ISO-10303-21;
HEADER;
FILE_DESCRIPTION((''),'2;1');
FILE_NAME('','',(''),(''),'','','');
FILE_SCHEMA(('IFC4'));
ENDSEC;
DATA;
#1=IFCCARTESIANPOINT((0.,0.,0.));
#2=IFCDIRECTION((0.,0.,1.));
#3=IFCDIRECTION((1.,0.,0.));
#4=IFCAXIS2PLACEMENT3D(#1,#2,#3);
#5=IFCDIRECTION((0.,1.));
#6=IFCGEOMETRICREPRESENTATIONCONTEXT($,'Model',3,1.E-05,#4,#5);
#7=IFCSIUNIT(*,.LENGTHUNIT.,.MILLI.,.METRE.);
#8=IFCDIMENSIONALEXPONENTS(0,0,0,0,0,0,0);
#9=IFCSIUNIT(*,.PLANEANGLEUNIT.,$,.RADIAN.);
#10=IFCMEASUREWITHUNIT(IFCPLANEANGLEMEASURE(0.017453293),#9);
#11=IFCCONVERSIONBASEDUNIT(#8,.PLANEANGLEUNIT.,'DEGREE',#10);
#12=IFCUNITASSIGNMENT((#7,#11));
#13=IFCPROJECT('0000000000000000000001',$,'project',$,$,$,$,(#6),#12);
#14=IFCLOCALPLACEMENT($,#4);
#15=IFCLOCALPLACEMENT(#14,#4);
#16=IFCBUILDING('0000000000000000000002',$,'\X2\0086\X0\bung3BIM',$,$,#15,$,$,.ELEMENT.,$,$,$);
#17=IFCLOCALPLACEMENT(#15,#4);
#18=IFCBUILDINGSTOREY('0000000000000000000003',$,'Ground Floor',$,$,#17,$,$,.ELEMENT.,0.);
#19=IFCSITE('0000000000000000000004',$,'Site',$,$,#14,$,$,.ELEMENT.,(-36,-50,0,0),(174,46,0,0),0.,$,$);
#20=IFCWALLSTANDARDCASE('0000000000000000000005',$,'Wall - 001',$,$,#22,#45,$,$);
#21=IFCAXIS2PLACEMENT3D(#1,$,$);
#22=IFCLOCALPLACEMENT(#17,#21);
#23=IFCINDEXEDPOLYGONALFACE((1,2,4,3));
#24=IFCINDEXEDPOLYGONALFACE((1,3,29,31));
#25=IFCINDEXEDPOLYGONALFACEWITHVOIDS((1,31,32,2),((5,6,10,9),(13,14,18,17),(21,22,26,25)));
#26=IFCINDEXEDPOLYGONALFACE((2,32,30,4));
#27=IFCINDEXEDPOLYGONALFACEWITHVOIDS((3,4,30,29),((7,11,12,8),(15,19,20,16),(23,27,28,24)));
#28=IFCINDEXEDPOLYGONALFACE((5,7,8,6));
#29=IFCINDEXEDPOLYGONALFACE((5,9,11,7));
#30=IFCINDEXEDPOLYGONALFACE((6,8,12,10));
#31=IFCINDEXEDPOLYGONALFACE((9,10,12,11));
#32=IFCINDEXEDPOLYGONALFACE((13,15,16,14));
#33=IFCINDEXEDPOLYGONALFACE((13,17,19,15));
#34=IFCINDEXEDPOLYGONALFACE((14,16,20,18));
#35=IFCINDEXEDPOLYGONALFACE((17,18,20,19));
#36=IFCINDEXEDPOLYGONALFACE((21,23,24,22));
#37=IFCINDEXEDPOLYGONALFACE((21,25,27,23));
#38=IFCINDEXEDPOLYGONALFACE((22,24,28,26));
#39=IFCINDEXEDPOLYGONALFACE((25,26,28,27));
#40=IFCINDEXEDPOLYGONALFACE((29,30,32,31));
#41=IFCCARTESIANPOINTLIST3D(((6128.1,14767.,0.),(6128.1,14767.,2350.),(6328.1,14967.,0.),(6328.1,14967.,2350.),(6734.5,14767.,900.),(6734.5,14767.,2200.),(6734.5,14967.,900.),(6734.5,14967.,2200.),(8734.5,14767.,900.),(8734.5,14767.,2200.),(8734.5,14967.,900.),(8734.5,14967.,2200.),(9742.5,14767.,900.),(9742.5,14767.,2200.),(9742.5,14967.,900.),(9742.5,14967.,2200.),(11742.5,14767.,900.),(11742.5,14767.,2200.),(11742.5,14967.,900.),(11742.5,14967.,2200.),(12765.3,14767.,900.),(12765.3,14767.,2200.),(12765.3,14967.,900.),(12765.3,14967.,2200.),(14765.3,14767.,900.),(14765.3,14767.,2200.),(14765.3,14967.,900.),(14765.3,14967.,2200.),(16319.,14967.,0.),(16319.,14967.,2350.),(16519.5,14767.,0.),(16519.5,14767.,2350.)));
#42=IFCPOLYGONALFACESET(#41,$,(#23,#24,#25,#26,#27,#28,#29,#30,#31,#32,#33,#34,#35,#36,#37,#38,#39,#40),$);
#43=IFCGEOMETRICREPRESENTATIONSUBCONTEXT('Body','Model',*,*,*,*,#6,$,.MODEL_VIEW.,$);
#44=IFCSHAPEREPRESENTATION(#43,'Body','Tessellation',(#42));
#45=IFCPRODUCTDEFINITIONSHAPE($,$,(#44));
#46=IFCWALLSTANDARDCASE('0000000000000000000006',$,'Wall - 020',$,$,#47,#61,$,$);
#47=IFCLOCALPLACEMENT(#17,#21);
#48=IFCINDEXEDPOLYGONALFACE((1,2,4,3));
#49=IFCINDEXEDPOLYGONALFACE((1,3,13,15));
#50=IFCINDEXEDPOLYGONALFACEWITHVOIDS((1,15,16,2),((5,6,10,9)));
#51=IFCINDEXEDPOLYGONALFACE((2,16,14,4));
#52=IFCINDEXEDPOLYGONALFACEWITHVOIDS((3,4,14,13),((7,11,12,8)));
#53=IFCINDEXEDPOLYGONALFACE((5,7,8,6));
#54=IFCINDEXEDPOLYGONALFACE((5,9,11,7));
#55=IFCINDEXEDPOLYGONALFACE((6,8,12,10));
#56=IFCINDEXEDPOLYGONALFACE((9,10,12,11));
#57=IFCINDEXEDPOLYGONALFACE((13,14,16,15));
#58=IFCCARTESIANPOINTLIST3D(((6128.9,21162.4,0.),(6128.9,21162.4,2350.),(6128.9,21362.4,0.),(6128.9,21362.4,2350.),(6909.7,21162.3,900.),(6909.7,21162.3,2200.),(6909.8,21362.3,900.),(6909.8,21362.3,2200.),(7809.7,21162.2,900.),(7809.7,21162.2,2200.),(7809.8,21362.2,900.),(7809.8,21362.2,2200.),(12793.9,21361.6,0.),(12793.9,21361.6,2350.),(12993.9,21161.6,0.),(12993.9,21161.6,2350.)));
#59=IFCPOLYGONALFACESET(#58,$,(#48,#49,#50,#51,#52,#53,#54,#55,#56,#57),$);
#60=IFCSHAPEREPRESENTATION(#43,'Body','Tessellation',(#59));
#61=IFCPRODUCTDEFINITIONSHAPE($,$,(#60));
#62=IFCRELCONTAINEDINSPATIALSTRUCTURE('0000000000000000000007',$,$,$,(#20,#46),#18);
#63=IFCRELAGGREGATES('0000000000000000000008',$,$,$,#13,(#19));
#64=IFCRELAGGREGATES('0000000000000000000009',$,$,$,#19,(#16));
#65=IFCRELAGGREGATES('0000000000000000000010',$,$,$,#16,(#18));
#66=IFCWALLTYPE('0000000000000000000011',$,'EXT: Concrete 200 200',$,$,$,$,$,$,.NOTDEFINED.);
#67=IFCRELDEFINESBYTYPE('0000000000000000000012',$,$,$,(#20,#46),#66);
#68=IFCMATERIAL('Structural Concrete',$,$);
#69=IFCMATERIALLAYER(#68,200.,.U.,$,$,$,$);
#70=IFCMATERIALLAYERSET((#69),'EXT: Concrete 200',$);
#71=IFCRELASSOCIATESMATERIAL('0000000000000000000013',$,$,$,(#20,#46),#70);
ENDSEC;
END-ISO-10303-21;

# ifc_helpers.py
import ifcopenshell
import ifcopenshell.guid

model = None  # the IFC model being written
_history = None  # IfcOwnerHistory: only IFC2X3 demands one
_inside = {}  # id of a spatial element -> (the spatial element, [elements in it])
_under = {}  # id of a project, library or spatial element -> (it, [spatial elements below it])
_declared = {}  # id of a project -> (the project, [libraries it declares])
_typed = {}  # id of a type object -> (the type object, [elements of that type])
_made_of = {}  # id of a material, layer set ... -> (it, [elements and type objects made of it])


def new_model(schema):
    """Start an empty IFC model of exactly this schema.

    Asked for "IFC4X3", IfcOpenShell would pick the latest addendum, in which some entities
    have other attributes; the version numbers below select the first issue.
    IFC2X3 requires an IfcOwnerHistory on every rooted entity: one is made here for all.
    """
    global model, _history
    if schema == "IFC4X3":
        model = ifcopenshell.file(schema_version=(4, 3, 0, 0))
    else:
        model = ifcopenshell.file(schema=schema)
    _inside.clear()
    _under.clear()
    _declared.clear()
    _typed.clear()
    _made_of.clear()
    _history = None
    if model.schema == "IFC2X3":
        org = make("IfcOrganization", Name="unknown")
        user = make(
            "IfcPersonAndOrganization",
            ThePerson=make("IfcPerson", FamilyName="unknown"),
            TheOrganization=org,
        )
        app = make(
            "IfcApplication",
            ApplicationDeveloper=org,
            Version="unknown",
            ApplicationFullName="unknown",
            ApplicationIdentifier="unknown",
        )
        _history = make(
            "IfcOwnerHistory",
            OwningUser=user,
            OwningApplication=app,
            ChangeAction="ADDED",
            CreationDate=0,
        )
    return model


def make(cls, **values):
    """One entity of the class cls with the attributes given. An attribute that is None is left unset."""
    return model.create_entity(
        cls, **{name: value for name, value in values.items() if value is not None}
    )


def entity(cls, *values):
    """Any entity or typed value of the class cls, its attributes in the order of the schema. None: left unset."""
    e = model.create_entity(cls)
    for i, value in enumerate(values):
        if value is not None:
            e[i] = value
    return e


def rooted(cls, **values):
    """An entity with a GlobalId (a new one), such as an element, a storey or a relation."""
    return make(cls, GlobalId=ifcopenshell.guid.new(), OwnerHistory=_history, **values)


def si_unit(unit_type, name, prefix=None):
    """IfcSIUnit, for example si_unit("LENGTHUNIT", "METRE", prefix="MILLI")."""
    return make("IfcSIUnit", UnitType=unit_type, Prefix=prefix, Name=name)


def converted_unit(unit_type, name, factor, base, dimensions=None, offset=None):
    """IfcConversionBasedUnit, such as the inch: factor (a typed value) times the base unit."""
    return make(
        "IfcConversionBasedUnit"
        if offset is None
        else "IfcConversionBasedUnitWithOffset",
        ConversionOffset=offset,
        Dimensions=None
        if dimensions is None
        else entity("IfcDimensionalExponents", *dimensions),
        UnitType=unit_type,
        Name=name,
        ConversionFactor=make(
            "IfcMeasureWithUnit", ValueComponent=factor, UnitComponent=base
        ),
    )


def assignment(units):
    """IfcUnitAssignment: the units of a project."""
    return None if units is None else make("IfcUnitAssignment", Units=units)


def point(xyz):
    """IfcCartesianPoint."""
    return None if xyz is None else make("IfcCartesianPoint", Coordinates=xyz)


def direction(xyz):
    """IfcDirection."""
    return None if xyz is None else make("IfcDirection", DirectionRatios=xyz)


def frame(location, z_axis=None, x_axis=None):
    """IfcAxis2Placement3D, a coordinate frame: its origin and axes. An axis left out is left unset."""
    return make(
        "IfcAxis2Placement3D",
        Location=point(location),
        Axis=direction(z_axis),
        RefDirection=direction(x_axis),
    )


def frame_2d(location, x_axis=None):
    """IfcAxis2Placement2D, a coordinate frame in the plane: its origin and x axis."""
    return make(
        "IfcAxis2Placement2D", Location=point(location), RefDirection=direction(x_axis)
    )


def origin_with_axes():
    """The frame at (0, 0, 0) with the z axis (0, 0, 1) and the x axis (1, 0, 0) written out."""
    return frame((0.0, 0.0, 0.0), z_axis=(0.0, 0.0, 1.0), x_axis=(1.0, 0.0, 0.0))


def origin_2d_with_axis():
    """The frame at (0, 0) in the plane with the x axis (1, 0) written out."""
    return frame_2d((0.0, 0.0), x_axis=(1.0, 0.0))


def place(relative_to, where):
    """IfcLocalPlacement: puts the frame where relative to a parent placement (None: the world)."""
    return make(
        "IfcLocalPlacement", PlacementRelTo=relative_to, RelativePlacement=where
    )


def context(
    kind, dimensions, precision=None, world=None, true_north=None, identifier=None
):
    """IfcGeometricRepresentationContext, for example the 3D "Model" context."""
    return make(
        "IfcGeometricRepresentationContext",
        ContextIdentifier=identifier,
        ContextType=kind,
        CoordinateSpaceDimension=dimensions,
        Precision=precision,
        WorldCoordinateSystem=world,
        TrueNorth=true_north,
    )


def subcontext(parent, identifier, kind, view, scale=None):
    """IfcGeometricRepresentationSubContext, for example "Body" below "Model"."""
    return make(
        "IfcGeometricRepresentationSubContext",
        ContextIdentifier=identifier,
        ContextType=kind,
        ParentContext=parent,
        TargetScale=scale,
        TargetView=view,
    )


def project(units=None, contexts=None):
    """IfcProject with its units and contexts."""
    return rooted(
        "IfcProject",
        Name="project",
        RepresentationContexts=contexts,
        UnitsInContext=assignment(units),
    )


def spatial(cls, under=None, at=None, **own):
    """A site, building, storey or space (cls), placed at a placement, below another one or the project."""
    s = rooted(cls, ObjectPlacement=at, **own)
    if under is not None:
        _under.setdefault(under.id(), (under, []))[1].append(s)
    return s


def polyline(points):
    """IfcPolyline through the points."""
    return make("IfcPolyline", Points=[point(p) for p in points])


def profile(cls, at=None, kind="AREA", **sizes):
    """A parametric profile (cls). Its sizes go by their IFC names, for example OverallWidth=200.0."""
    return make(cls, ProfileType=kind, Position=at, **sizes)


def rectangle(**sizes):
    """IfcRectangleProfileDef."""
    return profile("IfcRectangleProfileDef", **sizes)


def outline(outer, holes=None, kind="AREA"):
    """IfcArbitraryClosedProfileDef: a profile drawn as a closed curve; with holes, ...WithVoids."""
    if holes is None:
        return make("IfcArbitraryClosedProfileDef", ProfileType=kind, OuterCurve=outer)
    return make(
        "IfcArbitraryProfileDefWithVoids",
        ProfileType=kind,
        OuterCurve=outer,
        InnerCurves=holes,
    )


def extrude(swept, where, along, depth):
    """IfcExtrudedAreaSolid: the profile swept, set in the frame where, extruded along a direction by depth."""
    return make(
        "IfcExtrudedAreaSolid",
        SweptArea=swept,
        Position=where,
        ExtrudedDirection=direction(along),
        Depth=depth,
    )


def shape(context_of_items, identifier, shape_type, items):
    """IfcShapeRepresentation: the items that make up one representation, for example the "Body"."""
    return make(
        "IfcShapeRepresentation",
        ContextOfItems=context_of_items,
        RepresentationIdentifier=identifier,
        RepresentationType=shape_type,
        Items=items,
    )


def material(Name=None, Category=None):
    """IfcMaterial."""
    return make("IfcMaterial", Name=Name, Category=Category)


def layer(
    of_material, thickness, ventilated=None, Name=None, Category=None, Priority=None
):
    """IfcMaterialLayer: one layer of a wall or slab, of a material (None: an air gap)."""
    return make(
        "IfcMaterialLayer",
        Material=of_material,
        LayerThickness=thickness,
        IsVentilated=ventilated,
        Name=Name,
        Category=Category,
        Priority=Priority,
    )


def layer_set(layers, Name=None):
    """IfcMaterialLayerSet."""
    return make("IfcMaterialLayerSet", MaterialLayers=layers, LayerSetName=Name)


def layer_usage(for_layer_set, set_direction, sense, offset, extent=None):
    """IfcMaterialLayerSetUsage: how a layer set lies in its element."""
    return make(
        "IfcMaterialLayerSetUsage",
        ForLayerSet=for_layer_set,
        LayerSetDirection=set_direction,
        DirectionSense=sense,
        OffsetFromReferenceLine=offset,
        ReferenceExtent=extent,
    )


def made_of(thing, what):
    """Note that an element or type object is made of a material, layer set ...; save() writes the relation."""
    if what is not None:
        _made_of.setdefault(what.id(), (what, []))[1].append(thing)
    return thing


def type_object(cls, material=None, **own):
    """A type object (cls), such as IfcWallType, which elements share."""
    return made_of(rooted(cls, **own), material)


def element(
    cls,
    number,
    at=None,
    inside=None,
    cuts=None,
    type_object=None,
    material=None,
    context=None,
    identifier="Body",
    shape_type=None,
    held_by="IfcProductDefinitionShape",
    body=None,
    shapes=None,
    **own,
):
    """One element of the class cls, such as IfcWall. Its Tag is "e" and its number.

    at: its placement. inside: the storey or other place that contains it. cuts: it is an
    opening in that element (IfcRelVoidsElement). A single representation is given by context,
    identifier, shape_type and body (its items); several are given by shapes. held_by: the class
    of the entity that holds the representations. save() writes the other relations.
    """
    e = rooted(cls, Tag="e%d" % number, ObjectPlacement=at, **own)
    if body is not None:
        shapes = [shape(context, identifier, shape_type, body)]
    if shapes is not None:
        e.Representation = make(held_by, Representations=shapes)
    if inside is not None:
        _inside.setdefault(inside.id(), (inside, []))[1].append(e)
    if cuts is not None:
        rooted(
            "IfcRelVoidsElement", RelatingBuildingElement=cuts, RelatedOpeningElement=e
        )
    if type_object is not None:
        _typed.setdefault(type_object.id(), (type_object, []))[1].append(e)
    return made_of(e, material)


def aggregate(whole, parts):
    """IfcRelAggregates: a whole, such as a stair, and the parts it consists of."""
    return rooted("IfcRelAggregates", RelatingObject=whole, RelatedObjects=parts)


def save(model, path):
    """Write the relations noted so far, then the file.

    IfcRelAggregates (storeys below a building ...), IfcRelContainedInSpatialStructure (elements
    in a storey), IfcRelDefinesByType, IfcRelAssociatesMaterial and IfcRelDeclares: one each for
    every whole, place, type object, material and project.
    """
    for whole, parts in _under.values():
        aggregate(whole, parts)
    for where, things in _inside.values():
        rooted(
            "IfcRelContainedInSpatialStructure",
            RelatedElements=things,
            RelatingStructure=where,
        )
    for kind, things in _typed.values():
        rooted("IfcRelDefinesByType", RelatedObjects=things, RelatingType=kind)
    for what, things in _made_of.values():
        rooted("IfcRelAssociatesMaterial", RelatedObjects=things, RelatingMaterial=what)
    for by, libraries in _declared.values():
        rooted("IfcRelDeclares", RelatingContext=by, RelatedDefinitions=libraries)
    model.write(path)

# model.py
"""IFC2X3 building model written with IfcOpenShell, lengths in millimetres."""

from ifc_helpers import new_model, entity, si_unit, converted_unit, direction, frame, origin_with_axes, origin_2d_with_axis, place, context, subcontext, project, spatial, polyline, rectangle, outline, extrude, material, layer, layer_set, layer_usage, type_object, element, save


model = new_model("IFC2X3")

# Units and contexts
model_context = context("Model", 3, precision=1e-05, world=origin_with_axes(), true_north=direction((0.0, 1.0)))
body_context = subcontext(model_context, "Body", "Model", "MODEL_VIEW")
ifc_project = project(units=[si_unit("LENGTHUNIT", "METRE", prefix="MILLI"), converted_unit("PLANEANGLEUNIT", "DEGREE", entity("IfcPlaneAngleMeasure", 0.017453293), si_unit("PLANEANGLEUNIT", "RADIAN"), dimensions=[0, 0, 0, 0, 0, 0, 0])], contexts=[model_context])

# Site, building, storey
site_placement = place(None, origin_with_axes())
site = spatial("IfcSite", under=ifc_project, at=site_placement, Name="Site", CompositionType="ELEMENT", RefLatitude=(-36, -50, 0, 0), RefLongitude=(174, 46, 0, 0), RefElevation=0.0)
building_placement = place(site_placement, origin_with_axes())
building = spatial("IfcBuilding", under=site, at=building_placement, Name="\u0086bung3BIM", CompositionType="ELEMENT")
storey_placement = place(building_placement, origin_with_axes())
storey = spatial("IfcBuildingStorey", under=building, at=storey_placement, Name="Ground Floor", CompositionType="ELEMENT", Elevation=0.0)

# Shared definitions
ifc_material_1 = material(Name="Structural Concrete")
ifc_layer_1 = layer(ifc_material_1, 200.0, ventilated="UNKNOWN")
ifc_layer_set_1 = layer_set([ifc_layer_1], Name="EXT: Concrete 200")
wall_type_1 = type_object("IfcWallType", Name="EXT: Concrete 200 200", PredefinedType="NOTDEFINED")

# Wall, openings
ifc_layer_usage_1 = layer_usage(ifc_layer_set_1, "AXIS2", "POSITIVE", 0.0)
wall_1_placement = place(storey_placement, frame((16319.0, 14967.0, 0.0), z_axis=(0.0, 0.0, 1.0), x_axis=(-1.0, 0.0, 0.0)))
wall_1 = element("IfcWallStandardCase", 1, at=wall_1_placement, inside=storey, type_object=wall_type_1, material=ifc_layer_usage_1, Name="Wall - 001", context=body_context, shape_type="SweptSolid", body=[
    extrude(outline(polyline([(0.0, 0.0), (9990.9, 0.0), (10190.9, 200.0), (-200.5, 200.0), (0.0, 0.0)])), origin_with_axes(), (0.0, 0.0, 1.0), 2350.0),
])
opening_1_placement = place(wall_1_placement, frame((2553.7, 0.0, 900.0), z_axis=(0.0, 0.0, 1.0), x_axis=(1.0, 0.0, 0.0)))
element("IfcOpeningElement", 2, at=opening_1_placement, cuts=wall_1, context=body_context, shape_type="SweptSolid", body=[
    extrude(rectangle(XDim=2000.0, YDim=1300.0, at=origin_2d_with_axis()), frame((0.0, -200.0, 650.0), z_axis=(0.0, 1.0, 0.0), x_axis=(1.0, 0.0, 0.0)), (0.0, 0.0, 1.0), 600.0),
])
opening_2_placement = place(wall_1_placement, frame((5576.5, 0.0, 900.0), z_axis=(0.0, 0.0, 1.0), x_axis=(1.0, 0.0, 0.0)))
element("IfcOpeningElement", 3, at=opening_2_placement, cuts=wall_1, context=body_context, shape_type="SweptSolid", body=[
    extrude(rectangle(XDim=2000.0, YDim=1300.0, at=origin_2d_with_axis()), frame((0.0, -200.0, 650.0), z_axis=(0.0, 1.0, 0.0), x_axis=(1.0, 0.0, 0.0)), (0.0, 0.0, 1.0), 600.0),
])
opening_3_placement = place(wall_1_placement, frame((8584.5, 0.0, 900.0), z_axis=(0.0, 0.0, 1.0), x_axis=(1.0, 0.0, 0.0)))
element("IfcOpeningElement", 4, at=opening_3_placement, cuts=wall_1, context=body_context, shape_type="SweptSolid", body=[
    extrude(rectangle(XDim=2000.0, YDim=1300.0, at=origin_2d_with_axis()), frame((0.0, -200.0, 650.0), z_axis=(0.0, 1.0, 0.0), x_axis=(1.0, 0.0, 0.0)), (0.0, 0.0, 1.0), 600.0),
])

# Wall, opening
ifc_layer_usage_2 = layer_usage(ifc_layer_set_1, "AXIS2", "POSITIVE", 0.0)
wall_2_placement = place(storey_placement, frame((6128.9, 21162.4, 0.0), z_axis=(0.0, 0.0, 1.0), x_axis=(1.0, -0.000123, 0.0)))
wall_2 = element("IfcWallStandardCase", 5, at=wall_2_placement, inside=storey, type_object=wall_type_1, material=ifc_layer_usage_2, Name="Wall - 020", context=body_context, shape_type="SweptSolid", body=[
    extrude(outline(polyline([(0.0, 0.0), (6865.0, 0.0), (6665.0, 200.0), (0.0, 200.0), (0.0, 0.0)])), origin_with_axes(), (0.0, 0.0, 1.0), 2350.0),
])
opening_4_placement = place(wall_2_placement, frame((1230.8, 0.0, 900.0), z_axis=(0.0, 0.0, 1.0), x_axis=(1.0, 0.0, 0.0)))
element("IfcOpeningElement", 6, at=opening_4_placement, cuts=wall_2, context=body_context, shape_type="SweptSolid", body=[
    extrude(rectangle(XDim=900.0, YDim=1300.0, at=origin_2d_with_axis()), frame((0.0, -200.0, 650.0), z_axis=(0.0, -1.0, 0.0), x_axis=(-1.0, 0.0, 0.0)), (0.0, 0.0, -1.0), 600.0),
])

save(model, "model.ifc")
